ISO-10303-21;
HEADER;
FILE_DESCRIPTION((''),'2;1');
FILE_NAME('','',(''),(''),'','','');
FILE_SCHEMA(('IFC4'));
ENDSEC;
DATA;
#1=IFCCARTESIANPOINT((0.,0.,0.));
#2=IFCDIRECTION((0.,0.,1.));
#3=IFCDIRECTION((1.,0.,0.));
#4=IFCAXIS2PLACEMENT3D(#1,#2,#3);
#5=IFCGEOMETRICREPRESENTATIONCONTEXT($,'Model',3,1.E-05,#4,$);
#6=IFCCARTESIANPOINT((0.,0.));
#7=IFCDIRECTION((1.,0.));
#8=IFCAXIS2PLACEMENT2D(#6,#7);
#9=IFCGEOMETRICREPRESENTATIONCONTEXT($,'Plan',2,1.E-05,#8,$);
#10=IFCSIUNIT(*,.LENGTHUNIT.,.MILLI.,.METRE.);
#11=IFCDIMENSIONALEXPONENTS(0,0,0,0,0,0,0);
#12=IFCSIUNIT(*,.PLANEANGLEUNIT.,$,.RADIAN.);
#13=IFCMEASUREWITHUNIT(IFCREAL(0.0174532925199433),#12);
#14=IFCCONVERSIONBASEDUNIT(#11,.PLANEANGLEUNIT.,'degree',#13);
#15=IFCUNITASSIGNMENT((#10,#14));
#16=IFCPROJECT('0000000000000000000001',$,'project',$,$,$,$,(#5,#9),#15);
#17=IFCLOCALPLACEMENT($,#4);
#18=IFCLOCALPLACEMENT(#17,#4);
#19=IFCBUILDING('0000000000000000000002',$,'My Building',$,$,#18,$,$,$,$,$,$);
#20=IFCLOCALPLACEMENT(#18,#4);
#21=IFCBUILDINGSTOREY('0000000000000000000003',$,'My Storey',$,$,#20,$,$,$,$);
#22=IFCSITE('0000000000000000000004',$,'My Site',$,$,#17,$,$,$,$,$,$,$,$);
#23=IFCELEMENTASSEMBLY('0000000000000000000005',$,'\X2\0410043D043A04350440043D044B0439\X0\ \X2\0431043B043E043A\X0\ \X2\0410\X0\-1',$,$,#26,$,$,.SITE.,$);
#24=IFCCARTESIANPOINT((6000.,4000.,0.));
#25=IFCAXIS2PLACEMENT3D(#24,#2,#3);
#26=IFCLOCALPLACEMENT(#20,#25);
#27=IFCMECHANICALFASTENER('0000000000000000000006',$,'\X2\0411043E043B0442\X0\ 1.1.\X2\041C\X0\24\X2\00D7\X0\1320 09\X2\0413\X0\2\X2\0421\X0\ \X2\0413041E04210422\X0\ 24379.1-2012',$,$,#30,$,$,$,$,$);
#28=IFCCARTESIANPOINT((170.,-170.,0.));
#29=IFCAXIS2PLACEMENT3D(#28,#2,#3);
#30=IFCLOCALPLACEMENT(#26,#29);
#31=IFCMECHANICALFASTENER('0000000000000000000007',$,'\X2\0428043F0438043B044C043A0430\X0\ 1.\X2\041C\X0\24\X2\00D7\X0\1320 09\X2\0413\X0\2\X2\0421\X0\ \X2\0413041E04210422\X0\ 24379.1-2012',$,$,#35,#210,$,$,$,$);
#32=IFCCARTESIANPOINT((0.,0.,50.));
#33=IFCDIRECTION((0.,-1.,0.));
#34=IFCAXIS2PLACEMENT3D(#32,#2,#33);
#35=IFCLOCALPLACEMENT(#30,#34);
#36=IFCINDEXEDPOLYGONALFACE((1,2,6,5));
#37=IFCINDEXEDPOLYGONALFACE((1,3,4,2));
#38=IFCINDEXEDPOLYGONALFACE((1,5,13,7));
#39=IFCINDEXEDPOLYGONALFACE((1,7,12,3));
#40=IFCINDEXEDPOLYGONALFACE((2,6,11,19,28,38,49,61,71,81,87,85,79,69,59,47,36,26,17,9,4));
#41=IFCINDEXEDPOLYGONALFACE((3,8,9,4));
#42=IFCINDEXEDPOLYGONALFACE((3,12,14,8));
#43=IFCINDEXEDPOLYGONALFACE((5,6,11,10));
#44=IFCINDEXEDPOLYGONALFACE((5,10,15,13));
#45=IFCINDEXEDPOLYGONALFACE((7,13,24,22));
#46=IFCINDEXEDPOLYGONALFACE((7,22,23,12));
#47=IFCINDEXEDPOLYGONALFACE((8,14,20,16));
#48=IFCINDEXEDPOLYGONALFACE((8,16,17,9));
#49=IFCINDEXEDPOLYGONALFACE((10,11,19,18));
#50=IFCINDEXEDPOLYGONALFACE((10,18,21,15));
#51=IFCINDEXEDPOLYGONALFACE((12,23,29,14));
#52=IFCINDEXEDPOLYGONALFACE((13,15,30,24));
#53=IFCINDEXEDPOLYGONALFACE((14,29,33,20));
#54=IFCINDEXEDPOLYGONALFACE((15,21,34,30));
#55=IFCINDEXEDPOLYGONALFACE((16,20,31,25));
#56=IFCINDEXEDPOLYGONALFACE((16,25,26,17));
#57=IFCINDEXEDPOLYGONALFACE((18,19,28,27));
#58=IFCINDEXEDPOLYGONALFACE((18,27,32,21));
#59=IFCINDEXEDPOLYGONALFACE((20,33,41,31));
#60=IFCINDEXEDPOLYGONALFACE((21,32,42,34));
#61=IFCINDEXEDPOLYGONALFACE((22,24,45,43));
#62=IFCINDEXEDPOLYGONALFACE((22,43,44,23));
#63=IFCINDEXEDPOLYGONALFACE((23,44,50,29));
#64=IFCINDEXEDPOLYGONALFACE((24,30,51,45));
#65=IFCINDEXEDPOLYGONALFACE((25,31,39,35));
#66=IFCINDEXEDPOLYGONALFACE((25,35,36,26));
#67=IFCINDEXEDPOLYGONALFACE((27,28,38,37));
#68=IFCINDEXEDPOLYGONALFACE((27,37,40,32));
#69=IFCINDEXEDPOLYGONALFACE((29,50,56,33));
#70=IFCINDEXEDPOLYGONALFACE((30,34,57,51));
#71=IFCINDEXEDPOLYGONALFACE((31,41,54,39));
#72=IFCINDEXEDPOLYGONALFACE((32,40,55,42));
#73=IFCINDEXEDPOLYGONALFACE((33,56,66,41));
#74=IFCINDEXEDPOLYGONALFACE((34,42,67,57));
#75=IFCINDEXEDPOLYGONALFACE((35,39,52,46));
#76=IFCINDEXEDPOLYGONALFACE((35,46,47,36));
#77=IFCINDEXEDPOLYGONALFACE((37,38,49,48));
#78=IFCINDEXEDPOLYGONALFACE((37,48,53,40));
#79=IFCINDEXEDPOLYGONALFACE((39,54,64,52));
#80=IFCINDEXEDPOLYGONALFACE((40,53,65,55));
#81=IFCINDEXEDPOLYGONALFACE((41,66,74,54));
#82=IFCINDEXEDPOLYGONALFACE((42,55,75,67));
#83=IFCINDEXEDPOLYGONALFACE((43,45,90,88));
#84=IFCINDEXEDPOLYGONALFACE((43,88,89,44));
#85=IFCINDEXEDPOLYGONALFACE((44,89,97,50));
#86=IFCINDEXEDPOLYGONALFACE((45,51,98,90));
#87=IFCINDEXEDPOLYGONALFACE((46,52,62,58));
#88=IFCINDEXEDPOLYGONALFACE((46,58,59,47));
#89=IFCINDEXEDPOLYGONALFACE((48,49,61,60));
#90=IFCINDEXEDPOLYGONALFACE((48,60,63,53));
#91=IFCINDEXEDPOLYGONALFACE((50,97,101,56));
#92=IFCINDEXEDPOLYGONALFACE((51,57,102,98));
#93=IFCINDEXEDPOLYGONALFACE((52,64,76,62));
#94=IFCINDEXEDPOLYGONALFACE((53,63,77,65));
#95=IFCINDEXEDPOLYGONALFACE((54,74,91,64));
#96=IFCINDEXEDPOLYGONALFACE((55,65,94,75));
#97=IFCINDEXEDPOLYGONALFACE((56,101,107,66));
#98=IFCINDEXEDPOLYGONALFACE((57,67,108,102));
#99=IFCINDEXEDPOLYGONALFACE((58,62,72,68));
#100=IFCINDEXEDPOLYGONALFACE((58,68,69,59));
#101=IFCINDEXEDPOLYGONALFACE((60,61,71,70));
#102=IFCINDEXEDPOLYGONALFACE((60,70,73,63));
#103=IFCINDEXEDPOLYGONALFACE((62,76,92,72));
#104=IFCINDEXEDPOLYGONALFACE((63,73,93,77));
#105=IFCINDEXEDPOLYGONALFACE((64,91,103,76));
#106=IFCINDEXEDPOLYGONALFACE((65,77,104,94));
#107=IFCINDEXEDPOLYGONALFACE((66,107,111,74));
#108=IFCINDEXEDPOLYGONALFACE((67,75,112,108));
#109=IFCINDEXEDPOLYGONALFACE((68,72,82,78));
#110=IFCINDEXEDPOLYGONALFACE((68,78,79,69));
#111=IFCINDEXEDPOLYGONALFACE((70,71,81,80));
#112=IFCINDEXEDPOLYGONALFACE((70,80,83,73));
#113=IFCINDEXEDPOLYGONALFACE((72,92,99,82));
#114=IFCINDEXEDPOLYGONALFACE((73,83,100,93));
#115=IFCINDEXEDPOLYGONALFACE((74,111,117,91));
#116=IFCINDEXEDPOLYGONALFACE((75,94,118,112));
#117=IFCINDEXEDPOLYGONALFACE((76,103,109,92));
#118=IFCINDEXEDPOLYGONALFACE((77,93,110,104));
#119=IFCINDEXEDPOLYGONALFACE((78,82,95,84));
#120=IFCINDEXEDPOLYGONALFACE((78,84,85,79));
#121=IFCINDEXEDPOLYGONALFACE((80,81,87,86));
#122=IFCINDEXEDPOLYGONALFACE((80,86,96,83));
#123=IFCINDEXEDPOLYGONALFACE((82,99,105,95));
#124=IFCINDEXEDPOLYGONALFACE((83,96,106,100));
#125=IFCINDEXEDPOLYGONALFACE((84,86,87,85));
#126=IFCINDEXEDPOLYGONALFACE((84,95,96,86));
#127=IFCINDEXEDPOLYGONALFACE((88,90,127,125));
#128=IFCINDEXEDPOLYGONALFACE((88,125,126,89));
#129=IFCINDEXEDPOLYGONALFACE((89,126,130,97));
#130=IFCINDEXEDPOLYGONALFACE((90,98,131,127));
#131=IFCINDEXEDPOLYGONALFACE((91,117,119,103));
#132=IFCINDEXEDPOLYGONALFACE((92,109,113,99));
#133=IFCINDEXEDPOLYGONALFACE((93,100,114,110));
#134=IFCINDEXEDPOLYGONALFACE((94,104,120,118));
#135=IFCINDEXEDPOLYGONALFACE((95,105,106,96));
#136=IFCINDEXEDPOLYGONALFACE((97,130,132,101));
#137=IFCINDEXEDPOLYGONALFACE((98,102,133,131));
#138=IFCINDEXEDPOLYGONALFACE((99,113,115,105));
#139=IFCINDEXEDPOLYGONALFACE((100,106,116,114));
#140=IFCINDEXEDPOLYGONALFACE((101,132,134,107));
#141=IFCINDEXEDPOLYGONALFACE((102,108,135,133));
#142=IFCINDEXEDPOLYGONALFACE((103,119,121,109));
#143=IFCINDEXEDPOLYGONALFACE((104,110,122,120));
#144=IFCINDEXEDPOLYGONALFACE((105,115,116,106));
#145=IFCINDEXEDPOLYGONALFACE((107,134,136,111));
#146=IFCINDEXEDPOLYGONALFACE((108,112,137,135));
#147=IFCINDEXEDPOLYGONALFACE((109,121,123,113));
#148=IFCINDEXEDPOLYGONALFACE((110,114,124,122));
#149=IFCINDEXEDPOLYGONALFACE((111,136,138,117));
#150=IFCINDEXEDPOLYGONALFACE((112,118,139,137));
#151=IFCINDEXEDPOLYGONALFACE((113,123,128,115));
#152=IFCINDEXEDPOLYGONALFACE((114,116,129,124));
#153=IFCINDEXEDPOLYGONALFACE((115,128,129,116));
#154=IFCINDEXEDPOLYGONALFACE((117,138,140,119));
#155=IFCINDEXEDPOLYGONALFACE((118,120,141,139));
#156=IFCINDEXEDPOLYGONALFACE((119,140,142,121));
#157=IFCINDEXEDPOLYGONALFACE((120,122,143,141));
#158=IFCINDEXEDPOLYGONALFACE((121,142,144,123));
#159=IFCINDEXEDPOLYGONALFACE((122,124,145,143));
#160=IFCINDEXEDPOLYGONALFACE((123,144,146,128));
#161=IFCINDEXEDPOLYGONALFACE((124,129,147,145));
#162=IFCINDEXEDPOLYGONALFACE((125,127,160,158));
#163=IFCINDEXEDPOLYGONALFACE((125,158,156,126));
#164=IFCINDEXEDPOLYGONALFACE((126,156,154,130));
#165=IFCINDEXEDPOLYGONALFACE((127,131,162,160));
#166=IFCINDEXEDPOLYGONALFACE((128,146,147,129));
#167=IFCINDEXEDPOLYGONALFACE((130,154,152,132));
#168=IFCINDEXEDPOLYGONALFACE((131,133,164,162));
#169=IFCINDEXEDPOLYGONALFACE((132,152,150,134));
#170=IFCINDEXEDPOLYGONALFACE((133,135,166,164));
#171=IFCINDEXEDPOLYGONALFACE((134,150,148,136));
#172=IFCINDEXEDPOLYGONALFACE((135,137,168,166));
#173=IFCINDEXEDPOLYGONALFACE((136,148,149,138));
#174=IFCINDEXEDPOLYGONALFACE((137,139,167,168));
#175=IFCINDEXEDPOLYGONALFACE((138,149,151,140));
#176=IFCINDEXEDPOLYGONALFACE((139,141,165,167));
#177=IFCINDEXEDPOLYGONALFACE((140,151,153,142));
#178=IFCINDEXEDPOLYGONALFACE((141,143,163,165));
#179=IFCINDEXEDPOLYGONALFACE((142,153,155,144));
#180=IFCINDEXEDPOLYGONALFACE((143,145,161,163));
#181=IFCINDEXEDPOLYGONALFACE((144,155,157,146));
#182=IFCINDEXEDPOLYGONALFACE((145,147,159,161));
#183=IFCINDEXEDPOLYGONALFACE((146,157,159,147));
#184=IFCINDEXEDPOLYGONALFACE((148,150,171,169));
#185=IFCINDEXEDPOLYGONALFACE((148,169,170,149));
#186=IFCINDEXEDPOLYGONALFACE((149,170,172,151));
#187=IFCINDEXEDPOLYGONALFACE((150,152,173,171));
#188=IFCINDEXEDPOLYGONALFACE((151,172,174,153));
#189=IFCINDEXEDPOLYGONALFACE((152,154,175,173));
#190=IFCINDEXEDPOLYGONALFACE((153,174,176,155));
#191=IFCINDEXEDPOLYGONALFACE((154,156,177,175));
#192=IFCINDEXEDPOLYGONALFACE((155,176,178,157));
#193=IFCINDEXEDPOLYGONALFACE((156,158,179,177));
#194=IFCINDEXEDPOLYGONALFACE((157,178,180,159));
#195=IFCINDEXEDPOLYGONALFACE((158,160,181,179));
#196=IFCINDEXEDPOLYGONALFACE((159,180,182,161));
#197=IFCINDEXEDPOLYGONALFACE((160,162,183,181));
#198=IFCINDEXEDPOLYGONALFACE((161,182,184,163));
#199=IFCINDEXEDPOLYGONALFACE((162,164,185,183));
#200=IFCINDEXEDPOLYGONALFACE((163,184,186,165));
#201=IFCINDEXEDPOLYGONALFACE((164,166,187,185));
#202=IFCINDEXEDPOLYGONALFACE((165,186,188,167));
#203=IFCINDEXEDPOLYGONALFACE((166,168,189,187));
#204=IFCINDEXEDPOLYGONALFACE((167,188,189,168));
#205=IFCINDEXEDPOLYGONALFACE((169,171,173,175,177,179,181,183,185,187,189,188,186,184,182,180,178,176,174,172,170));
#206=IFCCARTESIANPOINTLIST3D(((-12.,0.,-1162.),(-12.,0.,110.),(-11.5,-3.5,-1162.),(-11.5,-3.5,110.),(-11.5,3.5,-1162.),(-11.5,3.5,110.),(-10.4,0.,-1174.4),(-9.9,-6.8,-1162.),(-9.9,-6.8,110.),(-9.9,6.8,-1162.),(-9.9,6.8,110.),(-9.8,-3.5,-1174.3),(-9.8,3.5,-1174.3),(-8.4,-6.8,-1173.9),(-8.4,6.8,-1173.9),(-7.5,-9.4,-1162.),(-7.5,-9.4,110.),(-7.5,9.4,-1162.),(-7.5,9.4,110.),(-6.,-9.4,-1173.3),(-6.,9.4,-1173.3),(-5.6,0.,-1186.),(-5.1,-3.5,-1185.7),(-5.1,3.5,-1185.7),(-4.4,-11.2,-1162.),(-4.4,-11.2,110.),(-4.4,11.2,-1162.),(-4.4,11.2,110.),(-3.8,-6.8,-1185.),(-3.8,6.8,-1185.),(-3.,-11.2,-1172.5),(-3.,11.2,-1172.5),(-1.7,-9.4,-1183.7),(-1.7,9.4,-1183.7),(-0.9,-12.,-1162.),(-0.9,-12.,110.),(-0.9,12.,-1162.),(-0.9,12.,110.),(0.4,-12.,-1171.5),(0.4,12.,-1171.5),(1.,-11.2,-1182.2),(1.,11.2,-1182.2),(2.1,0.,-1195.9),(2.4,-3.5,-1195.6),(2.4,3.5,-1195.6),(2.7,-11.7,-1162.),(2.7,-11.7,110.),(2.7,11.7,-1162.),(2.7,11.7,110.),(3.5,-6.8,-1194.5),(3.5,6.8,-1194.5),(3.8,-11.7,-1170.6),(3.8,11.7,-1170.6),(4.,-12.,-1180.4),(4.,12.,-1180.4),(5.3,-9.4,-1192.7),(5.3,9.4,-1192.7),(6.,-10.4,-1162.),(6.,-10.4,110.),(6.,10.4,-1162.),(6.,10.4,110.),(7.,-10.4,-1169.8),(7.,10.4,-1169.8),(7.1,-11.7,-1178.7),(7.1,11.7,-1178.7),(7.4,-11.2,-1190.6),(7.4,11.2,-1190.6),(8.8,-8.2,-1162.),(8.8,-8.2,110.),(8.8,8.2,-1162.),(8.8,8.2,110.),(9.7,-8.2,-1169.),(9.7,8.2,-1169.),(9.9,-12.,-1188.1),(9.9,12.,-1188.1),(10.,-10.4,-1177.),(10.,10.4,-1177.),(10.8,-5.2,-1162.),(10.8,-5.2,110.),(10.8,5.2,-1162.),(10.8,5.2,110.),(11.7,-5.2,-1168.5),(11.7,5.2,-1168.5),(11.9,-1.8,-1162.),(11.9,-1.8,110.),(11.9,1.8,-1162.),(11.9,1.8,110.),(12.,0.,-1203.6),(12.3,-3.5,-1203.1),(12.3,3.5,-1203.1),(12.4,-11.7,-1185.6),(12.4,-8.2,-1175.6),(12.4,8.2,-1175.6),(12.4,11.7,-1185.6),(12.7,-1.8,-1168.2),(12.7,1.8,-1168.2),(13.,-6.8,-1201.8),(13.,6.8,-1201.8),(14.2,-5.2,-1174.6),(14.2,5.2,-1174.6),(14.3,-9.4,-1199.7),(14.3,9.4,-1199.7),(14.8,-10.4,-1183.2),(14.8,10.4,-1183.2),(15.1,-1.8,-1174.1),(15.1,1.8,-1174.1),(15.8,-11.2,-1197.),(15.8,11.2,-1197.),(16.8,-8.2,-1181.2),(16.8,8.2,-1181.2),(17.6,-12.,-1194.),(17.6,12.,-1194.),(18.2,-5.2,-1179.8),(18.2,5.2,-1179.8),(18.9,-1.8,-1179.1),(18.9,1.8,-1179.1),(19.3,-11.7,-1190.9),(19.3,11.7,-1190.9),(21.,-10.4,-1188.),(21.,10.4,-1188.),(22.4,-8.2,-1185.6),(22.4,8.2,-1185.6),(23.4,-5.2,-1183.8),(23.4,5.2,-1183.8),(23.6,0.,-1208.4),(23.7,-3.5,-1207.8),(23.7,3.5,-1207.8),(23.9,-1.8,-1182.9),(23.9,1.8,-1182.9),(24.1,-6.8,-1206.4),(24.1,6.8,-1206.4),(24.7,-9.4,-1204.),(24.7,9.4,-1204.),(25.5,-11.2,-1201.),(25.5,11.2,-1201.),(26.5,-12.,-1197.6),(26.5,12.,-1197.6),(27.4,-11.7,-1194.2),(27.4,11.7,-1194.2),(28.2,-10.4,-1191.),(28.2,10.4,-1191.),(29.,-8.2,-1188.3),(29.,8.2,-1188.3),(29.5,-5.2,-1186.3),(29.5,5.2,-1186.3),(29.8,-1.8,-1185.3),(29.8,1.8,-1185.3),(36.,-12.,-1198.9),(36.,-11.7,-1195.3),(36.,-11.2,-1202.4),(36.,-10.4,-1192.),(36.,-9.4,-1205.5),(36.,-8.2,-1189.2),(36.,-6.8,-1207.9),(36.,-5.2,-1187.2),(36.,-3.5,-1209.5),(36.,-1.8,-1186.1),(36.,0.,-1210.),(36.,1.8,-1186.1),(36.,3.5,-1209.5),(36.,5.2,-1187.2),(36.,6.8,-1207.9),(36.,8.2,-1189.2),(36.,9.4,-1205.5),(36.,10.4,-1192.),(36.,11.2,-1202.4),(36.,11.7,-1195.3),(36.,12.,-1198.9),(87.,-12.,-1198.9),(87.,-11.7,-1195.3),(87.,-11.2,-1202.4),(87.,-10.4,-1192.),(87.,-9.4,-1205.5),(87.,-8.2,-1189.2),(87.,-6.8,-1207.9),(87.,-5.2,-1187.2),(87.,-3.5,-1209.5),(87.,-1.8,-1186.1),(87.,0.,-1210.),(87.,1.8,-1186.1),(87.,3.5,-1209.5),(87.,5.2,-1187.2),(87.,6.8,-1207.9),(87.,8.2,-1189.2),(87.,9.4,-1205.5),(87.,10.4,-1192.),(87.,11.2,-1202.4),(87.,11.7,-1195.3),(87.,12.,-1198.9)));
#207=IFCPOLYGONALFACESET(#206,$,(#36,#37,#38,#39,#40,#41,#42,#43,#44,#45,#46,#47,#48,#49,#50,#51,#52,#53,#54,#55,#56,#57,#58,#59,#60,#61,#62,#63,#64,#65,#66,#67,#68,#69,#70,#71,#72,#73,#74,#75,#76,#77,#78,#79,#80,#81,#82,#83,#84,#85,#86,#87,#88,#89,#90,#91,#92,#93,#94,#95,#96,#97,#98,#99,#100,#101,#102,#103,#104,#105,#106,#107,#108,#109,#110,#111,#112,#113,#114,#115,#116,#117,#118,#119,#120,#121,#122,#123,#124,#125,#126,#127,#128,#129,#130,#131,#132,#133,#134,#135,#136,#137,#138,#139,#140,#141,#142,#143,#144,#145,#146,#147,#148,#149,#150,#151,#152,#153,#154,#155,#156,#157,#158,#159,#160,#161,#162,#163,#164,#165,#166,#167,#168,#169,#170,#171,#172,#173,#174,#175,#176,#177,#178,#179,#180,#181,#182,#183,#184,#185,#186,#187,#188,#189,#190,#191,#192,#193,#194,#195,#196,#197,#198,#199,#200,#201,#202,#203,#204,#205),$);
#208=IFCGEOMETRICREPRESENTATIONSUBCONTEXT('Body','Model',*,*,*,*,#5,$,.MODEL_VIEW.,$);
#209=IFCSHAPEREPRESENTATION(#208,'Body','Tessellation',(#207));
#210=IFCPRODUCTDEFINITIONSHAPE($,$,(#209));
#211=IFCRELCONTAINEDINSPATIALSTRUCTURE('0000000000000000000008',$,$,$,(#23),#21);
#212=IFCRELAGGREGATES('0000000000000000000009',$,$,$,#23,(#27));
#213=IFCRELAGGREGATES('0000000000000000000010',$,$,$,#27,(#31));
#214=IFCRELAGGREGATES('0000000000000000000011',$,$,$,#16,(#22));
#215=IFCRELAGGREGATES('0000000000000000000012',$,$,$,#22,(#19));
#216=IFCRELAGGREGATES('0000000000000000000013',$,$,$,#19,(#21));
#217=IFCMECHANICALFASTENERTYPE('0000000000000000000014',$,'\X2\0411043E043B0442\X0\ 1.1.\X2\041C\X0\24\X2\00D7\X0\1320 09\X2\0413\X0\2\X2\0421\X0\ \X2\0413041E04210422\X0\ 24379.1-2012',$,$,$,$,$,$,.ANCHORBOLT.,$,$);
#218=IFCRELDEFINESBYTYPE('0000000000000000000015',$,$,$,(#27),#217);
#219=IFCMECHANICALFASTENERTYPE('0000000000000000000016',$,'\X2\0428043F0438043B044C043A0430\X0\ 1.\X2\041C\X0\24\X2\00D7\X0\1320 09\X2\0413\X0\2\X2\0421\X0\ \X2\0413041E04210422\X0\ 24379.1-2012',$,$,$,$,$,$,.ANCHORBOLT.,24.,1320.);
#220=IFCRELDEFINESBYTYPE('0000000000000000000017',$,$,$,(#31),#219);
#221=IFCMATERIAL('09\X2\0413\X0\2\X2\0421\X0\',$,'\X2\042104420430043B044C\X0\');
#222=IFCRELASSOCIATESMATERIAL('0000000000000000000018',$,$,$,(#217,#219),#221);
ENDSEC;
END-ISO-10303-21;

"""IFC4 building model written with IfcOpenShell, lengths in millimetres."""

from ifc_helpers import new_model, entity, si_unit, converted_unit, frame, origin_with_axes, origin_2d_with_axis, place, context, subcontext, project, spatial, source, transform, mapped, material, type_object, type_shapes, element, aggregate, save


model = new_model("IFC4")

# Units and contexts
model_context = context("Model", 3, precision=1e-05, world=origin_with_axes())
plan_context = context("Plan", 2, precision=1e-05, world=origin_2d_with_axis())
body_context = subcontext(model_context, "Body", "Model", "MODEL_VIEW")
ifc_project = project(units=[si_unit("LENGTHUNIT", "METRE", prefix="MILLI"), converted_unit("PLANEANGLEUNIT", "degree", entity("IfcReal", 0.0174532925199433), si_unit("PLANEANGLEUNIT", "RADIAN"), dimensions=[0, 0, 0, 0, 0, 0, 0])], contexts=[model_context, plan_context])

# Site, building, storey
site_placement = place(None, origin_with_axes())
site = spatial("IfcSite", under=ifc_project, at=site_placement, Name="My Site")
building_placement = place(site_placement, origin_with_axes())
building = spatial("IfcBuilding", under=site, at=building_placement, Name="My Building")
storey_placement = place(building_placement, origin_with_axes())
storey = spatial("IfcBuildingStorey", under=building, at=storey_placement, Name="My Storey")

# Element assembly, mechanical fasteners
assembly_1_placement = place(storey_placement, frame((6000.0, 4000.0, 0.0), z_axis=(0.0, 0.0, 1.0), x_axis=(1.0, 0.0, 0.0)))
assembly_1 = element("IfcElementAssembly", 1, at=assembly_1_placement, inside=storey, Name="Анкерный блок А-1", AssemblyPlace="SITE")
ifc_material_1 = material(Name="09Г2С", Category="Сталь")
mechanical_fastener_type_1 = type_object("IfcMechanicalFastenerType", Name="Болт 1.1.М24×1320 09Г2С ГОСТ 24379.1-2012", PredefinedType="ANCHORBOLT", material=ifc_material_1)
mechanical_fastener_1_placement = place(assembly_1_placement, frame((170.0, -170.0, 0.0), z_axis=(0.0, 0.0, 1.0), x_axis=(1.0, 0.0, 0.0)))
mechanical_fastener_1 = element("IfcMechanicalFastener", 2, at=mechanical_fastener_1_placement, type_object=mechanical_fastener_type_1, Name="Болт 1.1.М24×1320 09Г2С ГОСТ 24379.1-2012")
mechanical_fastener_type_2 = type_object("IfcMechanicalFastenerType", Name="Шпилька 1.М24×1320 09Г2С ГОСТ 24379.1-2012", NominalDiameter=24.0, NominalLength=1320.0, PredefinedType="ANCHORBOLT", material=ifc_material_1)
shared_shape_1 = source(frame((0.0, 0.0, 110.0), z_axis=(0.0, 0.0, 1.0), x_axis=(1.0, 0.0, 0.0)), body_context, "Body", "AdvancedSweptSolid", [
    entity("IfcSweptDiskSolid", entity("IfcIndexedPolyCurve", entity("IfcCartesianPointList3D", [[0.0, 0.0, 0.0], [0.0, 0.0, -1272.0], [10.5, 0.0, -1297.5], [36.0, 0.0, -1308.0], [87.0, 0.0, -1308.0]]), [entity("IfcLineIndex", [1, 2]), entity("IfcArcIndex", [2, 3, 4]), entity("IfcLineIndex", [4, 5])]), 12.0),
])
type_shapes(mechanical_fastener_type_2, [shared_shape_1])
mechanical_fastener_2_placement = place(mechanical_fastener_1_placement, frame((0.0, 0.0, 50.0), z_axis=(0.0, 0.0, 1.0), x_axis=(0.0, -1.0, 0.0)))
mechanical_fastener_2 = element("IfcMechanicalFastener", 3, at=mechanical_fastener_2_placement, type_object=mechanical_fastener_type_2, Name="Шпилька 1.М24×1320 09Г2С ГОСТ 24379.1-2012", context=body_context, shape_type="MappedRepresentation", body=[
    mapped(shared_shape_1, transform((0.0, 0.0, 0.0), x_axis=(1.0, 0.0, 0.0), y_axis=(0.0, 1.0, 0.0), z_axis=(0.0, 0.0, 1.0), scale=1.0)),
])
aggregate(assembly_1, [mechanical_fastener_1])

aggregate(mechanical_fastener_1, [mechanical_fastener_2])

save(model, "model.ifc")
